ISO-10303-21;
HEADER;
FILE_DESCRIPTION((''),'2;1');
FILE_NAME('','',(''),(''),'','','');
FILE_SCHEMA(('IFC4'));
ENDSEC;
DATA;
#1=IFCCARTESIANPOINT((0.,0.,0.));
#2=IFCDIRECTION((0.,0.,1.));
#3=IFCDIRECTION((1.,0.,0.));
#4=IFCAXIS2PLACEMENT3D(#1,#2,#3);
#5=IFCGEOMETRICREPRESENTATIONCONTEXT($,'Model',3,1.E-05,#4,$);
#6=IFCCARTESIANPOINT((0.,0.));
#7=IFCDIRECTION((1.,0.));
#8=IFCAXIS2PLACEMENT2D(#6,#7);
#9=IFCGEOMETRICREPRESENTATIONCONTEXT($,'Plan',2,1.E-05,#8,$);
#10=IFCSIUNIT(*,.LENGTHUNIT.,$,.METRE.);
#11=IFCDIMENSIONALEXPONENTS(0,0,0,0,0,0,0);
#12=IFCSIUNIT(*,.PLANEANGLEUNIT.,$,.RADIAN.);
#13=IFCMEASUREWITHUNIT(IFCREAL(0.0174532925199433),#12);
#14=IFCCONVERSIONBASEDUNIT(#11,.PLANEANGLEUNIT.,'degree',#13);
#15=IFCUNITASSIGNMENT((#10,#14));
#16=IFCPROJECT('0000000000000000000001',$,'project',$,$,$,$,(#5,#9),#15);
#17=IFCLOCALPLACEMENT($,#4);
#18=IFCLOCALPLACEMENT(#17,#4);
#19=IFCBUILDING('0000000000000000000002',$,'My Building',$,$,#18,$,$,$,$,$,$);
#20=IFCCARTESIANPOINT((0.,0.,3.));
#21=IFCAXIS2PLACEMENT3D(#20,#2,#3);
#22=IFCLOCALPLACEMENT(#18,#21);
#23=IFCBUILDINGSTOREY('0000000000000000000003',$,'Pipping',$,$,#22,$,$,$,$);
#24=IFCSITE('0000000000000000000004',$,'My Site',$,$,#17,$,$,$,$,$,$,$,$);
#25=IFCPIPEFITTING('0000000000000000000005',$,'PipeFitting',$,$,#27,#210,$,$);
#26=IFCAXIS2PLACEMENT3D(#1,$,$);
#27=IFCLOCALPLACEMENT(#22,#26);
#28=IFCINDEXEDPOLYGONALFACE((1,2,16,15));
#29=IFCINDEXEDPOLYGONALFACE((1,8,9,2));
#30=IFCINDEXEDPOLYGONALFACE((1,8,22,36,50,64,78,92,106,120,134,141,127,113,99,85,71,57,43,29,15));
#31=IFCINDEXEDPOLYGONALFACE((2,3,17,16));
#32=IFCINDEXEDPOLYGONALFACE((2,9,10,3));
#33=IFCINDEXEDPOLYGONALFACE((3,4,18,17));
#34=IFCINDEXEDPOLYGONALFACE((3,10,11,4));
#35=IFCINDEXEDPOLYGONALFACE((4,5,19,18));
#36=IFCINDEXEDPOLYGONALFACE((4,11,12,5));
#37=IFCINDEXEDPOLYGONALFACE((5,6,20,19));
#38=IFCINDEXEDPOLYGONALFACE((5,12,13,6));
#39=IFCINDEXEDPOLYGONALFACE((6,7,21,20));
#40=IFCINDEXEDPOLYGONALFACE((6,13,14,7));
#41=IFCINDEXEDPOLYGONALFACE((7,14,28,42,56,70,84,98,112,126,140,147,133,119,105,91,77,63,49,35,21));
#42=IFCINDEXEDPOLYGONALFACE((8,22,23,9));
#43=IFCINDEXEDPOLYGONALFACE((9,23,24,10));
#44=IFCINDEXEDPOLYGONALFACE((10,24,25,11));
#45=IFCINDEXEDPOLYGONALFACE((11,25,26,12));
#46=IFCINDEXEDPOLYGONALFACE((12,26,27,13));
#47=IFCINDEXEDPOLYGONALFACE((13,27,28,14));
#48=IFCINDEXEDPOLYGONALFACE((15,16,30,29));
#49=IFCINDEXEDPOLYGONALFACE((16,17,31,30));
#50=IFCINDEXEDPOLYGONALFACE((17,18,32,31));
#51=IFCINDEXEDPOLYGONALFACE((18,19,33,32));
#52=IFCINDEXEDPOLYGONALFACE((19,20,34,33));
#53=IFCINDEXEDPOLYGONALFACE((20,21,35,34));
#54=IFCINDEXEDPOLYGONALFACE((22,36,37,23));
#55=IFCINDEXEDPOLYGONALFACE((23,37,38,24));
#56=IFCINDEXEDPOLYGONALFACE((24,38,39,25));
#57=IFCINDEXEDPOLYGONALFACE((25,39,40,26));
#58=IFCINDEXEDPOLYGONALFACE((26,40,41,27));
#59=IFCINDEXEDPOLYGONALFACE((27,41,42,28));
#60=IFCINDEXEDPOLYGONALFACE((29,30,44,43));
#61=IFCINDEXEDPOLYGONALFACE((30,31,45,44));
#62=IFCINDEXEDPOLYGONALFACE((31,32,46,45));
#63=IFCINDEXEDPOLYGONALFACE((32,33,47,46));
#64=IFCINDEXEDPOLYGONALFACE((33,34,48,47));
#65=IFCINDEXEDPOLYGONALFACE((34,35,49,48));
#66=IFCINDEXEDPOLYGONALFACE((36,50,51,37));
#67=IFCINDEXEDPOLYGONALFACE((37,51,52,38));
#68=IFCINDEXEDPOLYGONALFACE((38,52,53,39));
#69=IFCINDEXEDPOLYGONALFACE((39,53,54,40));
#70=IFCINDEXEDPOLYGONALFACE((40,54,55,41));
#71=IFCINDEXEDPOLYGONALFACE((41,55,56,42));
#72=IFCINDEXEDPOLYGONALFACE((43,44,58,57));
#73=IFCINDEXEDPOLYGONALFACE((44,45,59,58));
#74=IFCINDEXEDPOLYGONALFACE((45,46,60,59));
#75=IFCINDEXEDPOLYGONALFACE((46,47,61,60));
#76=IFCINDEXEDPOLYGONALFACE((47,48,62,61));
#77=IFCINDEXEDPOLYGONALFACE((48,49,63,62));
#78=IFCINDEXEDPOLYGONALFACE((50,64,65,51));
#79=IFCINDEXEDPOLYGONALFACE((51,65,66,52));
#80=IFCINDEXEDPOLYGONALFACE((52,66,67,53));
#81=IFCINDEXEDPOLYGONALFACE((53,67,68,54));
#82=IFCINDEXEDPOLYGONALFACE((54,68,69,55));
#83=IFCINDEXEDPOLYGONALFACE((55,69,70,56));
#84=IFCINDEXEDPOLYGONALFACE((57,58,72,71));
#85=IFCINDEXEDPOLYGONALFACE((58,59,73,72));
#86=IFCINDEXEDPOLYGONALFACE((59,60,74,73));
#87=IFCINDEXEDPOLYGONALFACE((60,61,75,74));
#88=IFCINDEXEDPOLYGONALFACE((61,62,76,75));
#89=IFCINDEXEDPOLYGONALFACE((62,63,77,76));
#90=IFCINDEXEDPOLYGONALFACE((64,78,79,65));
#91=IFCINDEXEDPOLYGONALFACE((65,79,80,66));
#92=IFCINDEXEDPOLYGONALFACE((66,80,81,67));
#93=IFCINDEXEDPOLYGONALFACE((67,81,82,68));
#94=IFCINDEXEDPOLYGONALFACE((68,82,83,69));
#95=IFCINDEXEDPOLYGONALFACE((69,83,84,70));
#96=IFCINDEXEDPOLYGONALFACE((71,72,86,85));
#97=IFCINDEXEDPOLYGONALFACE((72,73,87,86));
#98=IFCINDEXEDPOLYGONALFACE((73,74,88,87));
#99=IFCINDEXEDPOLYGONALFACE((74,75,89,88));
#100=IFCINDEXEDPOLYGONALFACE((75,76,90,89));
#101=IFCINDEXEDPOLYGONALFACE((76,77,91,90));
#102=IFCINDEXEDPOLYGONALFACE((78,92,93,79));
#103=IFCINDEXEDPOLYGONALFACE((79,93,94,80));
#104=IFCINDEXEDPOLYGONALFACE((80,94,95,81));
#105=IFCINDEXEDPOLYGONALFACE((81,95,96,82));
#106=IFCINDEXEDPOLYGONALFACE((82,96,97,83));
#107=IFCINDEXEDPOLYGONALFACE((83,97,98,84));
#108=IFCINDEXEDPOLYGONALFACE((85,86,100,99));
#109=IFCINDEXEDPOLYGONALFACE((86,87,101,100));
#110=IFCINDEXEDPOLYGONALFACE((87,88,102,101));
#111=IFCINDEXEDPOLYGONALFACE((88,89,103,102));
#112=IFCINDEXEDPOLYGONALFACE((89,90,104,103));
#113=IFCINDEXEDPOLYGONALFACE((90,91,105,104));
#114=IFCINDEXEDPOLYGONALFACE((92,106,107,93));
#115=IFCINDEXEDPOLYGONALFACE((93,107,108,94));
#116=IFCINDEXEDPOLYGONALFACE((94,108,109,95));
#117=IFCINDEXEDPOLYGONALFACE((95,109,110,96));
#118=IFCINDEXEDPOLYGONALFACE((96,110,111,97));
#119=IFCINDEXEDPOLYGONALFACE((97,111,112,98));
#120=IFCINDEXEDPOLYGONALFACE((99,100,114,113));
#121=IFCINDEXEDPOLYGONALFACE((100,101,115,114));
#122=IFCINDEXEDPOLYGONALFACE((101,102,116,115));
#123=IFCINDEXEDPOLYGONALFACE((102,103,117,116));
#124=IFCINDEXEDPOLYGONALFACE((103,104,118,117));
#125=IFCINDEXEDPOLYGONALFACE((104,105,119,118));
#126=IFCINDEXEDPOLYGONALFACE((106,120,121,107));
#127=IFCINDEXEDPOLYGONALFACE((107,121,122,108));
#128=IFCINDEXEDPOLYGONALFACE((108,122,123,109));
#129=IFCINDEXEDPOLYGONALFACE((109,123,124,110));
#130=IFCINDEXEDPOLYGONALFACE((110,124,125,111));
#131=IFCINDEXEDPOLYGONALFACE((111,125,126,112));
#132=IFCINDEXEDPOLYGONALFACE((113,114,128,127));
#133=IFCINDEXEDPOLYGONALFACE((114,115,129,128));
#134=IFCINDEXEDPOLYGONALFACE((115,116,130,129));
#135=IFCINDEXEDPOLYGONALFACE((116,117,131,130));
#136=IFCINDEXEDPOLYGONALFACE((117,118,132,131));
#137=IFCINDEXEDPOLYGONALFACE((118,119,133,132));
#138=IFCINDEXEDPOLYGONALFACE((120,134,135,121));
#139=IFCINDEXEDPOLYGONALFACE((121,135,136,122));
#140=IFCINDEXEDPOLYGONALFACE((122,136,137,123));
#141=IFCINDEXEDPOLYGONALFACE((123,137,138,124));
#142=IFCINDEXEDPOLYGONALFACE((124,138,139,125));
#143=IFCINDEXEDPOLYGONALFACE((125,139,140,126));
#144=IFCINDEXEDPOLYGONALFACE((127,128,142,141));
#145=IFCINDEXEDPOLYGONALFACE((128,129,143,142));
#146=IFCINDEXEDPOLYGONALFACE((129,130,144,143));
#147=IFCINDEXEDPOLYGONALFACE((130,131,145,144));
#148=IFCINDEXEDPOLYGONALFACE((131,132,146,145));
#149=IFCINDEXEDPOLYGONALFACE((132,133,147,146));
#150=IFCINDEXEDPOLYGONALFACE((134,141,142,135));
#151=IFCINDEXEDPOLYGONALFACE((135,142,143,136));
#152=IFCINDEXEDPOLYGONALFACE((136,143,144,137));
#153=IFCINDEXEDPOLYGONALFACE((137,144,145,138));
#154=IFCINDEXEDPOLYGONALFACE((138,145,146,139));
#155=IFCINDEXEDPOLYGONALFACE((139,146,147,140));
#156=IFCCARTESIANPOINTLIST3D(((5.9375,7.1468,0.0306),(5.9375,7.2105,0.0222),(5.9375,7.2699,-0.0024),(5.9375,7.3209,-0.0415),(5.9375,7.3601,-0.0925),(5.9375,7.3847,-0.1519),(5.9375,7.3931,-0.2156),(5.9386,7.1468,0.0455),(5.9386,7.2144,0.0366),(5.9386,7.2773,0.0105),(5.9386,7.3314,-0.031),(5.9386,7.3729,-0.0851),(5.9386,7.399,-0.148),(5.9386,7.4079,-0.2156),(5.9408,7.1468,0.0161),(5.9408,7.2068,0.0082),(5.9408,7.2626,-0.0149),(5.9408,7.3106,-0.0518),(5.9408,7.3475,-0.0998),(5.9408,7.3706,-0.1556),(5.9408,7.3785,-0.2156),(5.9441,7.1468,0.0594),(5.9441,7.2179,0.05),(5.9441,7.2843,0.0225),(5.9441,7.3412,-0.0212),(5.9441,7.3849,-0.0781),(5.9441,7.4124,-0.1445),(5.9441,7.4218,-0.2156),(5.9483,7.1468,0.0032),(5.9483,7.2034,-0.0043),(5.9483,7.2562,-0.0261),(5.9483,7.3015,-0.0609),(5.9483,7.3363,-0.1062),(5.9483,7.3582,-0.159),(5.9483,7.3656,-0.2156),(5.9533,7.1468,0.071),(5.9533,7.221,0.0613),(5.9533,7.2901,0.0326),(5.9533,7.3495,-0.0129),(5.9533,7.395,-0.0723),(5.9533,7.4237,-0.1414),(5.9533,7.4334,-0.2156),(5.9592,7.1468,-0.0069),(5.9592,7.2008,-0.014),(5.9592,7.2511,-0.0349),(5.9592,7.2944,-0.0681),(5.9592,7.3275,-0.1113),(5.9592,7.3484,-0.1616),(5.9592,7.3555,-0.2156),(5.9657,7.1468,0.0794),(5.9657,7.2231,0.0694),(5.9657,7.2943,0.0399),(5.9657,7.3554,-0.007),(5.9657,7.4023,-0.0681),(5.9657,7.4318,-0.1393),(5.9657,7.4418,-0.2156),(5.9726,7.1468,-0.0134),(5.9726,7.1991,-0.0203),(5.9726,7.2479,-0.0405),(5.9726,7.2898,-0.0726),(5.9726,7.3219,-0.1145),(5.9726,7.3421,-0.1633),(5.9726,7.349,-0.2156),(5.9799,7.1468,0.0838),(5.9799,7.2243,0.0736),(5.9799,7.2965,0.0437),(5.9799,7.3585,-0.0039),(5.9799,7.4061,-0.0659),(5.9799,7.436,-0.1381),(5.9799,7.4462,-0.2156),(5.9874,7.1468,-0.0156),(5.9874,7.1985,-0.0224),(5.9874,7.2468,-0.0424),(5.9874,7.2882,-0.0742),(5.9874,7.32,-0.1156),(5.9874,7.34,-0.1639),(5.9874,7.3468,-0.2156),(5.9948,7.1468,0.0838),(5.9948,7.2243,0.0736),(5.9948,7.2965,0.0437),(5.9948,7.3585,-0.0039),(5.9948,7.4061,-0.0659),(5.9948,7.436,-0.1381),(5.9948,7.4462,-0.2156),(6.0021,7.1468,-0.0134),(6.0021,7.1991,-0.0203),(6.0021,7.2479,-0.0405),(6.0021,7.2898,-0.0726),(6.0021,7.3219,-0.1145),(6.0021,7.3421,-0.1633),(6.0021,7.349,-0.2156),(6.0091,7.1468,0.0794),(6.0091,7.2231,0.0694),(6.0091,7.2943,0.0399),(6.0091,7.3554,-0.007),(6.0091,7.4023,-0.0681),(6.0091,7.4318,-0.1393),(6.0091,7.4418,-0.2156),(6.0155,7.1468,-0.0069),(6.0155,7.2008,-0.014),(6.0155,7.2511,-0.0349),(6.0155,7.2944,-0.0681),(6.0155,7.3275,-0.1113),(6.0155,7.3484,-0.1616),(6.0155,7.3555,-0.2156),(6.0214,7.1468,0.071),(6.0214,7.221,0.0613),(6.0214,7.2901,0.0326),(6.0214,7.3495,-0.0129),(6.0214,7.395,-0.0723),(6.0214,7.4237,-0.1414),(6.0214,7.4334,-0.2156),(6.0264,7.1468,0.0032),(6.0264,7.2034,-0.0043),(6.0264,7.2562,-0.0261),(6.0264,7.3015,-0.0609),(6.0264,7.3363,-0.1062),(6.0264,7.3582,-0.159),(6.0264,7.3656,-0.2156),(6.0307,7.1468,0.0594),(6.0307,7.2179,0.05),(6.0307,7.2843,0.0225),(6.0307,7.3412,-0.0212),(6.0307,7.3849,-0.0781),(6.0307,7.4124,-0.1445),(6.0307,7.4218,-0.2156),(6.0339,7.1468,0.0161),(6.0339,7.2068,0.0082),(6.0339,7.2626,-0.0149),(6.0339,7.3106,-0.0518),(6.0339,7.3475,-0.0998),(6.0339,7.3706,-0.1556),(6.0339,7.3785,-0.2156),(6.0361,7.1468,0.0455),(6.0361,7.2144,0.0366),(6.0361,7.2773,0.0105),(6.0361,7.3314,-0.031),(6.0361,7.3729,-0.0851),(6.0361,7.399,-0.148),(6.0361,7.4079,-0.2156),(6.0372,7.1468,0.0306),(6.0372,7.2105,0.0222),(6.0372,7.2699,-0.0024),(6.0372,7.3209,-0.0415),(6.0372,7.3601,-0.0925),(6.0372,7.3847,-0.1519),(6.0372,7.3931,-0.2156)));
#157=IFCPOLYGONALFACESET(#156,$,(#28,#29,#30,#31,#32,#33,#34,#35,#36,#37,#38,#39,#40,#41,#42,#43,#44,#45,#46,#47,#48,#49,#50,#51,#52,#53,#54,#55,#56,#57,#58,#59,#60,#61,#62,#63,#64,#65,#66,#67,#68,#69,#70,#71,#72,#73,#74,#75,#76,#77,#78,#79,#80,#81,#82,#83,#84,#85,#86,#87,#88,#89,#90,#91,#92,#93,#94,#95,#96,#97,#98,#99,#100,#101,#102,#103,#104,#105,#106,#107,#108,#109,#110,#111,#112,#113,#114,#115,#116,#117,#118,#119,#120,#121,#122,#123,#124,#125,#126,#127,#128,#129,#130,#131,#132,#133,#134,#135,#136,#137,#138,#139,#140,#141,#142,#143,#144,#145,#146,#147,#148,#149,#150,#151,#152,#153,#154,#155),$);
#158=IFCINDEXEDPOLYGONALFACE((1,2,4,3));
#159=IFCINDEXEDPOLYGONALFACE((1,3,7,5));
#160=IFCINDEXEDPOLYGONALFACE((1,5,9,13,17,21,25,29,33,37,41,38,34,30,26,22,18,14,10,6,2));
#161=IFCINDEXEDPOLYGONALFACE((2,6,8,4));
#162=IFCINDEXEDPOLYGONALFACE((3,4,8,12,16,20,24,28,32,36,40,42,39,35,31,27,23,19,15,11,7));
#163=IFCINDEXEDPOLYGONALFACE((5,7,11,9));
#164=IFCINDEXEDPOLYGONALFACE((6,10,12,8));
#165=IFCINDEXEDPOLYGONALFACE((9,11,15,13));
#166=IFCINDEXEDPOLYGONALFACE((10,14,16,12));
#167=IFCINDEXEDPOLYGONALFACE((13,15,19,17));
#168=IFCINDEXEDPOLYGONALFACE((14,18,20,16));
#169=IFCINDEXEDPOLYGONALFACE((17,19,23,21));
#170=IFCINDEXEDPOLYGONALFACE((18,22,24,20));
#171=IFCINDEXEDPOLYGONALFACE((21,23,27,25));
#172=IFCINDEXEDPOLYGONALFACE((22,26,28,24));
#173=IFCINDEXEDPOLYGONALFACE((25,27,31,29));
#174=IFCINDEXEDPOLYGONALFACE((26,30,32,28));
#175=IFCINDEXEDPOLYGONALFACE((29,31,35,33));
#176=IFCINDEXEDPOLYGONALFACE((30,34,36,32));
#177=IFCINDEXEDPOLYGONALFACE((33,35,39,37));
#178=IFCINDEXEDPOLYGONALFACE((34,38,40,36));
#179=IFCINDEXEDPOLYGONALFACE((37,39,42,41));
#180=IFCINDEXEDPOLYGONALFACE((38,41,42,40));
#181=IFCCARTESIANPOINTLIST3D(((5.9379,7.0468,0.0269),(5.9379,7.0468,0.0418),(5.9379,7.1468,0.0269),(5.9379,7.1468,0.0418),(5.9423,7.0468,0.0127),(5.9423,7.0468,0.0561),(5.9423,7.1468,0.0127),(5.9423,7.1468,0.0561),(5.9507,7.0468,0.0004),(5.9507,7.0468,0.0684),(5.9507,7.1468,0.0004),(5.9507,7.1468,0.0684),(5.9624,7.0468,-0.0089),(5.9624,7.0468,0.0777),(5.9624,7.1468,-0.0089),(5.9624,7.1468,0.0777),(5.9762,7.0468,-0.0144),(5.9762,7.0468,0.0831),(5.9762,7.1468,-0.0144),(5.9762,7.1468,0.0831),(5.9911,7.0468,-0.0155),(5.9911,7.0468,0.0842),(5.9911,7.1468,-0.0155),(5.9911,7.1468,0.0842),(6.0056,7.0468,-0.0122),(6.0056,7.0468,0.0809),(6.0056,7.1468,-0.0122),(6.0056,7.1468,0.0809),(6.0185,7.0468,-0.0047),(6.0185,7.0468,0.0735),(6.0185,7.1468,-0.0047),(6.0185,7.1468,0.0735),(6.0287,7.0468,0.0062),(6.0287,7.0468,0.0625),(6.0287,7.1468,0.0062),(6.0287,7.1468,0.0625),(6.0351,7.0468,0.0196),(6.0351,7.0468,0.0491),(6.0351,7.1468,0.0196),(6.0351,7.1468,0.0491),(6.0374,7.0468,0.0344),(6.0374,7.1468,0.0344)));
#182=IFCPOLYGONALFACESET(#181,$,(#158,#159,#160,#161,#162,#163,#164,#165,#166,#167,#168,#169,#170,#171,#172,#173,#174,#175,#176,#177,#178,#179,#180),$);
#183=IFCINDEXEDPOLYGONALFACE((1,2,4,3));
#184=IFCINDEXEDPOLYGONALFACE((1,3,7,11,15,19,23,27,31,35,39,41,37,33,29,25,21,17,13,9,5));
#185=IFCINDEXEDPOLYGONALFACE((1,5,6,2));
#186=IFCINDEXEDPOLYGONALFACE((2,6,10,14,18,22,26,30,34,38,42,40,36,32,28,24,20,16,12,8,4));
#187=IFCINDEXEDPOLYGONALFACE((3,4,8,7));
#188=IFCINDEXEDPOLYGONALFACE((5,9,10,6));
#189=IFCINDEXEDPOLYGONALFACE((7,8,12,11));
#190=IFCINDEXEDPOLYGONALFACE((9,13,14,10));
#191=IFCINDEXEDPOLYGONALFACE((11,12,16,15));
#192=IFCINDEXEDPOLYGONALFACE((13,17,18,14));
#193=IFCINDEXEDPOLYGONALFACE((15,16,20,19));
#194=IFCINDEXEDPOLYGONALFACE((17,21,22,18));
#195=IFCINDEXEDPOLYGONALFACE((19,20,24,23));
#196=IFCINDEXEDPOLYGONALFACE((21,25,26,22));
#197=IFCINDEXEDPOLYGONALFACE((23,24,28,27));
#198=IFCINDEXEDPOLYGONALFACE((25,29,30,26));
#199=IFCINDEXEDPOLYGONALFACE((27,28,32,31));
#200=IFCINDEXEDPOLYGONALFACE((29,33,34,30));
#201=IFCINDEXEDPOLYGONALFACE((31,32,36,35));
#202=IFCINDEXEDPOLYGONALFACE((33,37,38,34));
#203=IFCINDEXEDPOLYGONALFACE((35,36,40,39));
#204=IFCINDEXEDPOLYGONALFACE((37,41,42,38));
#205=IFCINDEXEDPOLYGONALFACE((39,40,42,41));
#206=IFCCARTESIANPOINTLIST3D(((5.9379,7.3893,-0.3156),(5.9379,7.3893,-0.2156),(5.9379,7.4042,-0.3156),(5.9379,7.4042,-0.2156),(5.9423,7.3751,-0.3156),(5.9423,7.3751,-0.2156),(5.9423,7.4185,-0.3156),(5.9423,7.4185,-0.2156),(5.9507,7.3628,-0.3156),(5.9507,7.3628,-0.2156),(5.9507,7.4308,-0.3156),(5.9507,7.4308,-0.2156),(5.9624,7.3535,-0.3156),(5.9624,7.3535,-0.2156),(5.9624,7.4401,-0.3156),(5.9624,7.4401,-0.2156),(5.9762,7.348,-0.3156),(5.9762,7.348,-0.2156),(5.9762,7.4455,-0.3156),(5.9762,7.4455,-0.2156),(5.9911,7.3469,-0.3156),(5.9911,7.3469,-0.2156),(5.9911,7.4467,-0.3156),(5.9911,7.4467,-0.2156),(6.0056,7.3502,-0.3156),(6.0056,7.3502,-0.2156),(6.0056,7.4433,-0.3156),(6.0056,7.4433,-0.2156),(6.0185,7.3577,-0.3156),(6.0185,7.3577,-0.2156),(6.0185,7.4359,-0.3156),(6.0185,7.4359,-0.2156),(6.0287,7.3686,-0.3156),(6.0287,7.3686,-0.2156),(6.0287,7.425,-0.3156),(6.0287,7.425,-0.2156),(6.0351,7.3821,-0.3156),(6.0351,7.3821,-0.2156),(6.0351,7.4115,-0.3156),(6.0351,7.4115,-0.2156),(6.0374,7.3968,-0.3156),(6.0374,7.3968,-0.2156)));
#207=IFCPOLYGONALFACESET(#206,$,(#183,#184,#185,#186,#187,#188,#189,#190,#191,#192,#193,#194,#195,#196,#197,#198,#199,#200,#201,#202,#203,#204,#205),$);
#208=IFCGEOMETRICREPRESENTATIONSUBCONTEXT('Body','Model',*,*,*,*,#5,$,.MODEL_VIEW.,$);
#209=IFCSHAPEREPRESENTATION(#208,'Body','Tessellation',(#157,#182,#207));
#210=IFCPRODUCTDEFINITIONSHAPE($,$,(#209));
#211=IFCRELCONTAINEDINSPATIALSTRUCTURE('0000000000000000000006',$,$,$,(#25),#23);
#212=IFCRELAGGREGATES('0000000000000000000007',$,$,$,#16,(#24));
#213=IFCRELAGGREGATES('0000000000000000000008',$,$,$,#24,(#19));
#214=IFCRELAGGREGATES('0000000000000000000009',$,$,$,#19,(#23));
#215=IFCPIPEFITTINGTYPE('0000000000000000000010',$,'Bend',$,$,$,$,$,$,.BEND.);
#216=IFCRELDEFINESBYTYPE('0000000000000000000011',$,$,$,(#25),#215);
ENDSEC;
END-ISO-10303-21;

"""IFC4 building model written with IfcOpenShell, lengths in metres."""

from ifc_helpers import new_model, entity, si_unit, converted_unit, frame, origin_with_axes, origin_2d_with_axis, place, context, subcontext, project, spatial, circle, extrude, source, transform, mapped, type_object, type_shapes, element, save


model = new_model("IFC4")

# Units and contexts
model_context = context("Model", 3, precision=1e-05, world=origin_with_axes())
plan_context = context("Plan", 2, precision=1e-05, world=origin_2d_with_axis())
body_context = subcontext(model_context, "Body", "Model", "MODEL_VIEW")
ifc_project = project(units=[si_unit("LENGTHUNIT", "METRE"), converted_unit("PLANEANGLEUNIT", "degree", entity("IfcReal", 0.0174532925199433), si_unit("PLANEANGLEUNIT", "RADIAN"), dimensions=[0, 0, 0, 0, 0, 0, 0])], contexts=[model_context, plan_context])

# Site, building, storey
site_placement = place(None, origin_with_axes())
site = spatial("IfcSite", under=ifc_project, at=site_placement, Name="My Site")
building_placement = place(site_placement, origin_with_axes())
building = spatial("IfcBuilding", under=site, at=building_placement, Name="My Building")
storey_placement = place(building_placement, frame((0.0, 0.0, 3.0), z_axis=(0.0, 0.0, 1.0), x_axis=(1.0, 0.0, 0.0)))
storey = spatial("IfcBuildingStorey", under=building, at=storey_placement, Name="Pipping")

# Pipe fitting
pipe_fitting_type_1 = type_object("IfcPipeFittingType", Name="Bend", PredefinedType="BEND")
shared_shape_1 = source(origin_with_axes(), body_context, "Body", "SolidModel", [
    entity("IfcSweptDiskSolid", entity("IfcIndexedPolyCurve", entity("IfcCartesianPointList3D", [[0.0, 0.0, 0.1], [0.0, 0.0732, 0.2768], [0.0, 0.25, 0.35]]), [entity("IfcArcIndex", [1, 2, 3])]), 0.05),
    extrude(circle(Radius=0.05), origin_with_axes(), (0.0, 0.0, 1.0), 0.1),
    extrude(circle(Radius=0.05), frame((0.0, 0.25, 0.35), z_axis=(0.0, 1.0, -0.000073), x_axis=(1.0, 0.0, 0.0)), (0.0, 0.0, 1.0), 0.1),
])
type_shapes(pipe_fitting_type_1, [shared_shape_1])
for number, where, z_axis, x_axis, name in (
    (1, (5.9874, 7.0468, 0.0344), (0.0, 1.0, 0.000073), (1.0, 0.0, 0.0), "PipeFitting"),
):
    element("IfcPipeFitting", number, at=place(storey_placement, frame(where, z_axis=z_axis, x_axis=x_axis)), inside=storey, type_object=pipe_fitting_type_1, Name=name, context=body_context, shape_type="MappedRepresentation", body=[
        mapped(shared_shape_1, transform((0.0, 0.0, 0.0), x_axis=(1.0, 0.0, 0.0), y_axis=(0.0, 1.0, 0.0), z_axis=(0.0, 0.0, 1.0), scale=1.0)),
    ])

save(model, "model.ifc")
